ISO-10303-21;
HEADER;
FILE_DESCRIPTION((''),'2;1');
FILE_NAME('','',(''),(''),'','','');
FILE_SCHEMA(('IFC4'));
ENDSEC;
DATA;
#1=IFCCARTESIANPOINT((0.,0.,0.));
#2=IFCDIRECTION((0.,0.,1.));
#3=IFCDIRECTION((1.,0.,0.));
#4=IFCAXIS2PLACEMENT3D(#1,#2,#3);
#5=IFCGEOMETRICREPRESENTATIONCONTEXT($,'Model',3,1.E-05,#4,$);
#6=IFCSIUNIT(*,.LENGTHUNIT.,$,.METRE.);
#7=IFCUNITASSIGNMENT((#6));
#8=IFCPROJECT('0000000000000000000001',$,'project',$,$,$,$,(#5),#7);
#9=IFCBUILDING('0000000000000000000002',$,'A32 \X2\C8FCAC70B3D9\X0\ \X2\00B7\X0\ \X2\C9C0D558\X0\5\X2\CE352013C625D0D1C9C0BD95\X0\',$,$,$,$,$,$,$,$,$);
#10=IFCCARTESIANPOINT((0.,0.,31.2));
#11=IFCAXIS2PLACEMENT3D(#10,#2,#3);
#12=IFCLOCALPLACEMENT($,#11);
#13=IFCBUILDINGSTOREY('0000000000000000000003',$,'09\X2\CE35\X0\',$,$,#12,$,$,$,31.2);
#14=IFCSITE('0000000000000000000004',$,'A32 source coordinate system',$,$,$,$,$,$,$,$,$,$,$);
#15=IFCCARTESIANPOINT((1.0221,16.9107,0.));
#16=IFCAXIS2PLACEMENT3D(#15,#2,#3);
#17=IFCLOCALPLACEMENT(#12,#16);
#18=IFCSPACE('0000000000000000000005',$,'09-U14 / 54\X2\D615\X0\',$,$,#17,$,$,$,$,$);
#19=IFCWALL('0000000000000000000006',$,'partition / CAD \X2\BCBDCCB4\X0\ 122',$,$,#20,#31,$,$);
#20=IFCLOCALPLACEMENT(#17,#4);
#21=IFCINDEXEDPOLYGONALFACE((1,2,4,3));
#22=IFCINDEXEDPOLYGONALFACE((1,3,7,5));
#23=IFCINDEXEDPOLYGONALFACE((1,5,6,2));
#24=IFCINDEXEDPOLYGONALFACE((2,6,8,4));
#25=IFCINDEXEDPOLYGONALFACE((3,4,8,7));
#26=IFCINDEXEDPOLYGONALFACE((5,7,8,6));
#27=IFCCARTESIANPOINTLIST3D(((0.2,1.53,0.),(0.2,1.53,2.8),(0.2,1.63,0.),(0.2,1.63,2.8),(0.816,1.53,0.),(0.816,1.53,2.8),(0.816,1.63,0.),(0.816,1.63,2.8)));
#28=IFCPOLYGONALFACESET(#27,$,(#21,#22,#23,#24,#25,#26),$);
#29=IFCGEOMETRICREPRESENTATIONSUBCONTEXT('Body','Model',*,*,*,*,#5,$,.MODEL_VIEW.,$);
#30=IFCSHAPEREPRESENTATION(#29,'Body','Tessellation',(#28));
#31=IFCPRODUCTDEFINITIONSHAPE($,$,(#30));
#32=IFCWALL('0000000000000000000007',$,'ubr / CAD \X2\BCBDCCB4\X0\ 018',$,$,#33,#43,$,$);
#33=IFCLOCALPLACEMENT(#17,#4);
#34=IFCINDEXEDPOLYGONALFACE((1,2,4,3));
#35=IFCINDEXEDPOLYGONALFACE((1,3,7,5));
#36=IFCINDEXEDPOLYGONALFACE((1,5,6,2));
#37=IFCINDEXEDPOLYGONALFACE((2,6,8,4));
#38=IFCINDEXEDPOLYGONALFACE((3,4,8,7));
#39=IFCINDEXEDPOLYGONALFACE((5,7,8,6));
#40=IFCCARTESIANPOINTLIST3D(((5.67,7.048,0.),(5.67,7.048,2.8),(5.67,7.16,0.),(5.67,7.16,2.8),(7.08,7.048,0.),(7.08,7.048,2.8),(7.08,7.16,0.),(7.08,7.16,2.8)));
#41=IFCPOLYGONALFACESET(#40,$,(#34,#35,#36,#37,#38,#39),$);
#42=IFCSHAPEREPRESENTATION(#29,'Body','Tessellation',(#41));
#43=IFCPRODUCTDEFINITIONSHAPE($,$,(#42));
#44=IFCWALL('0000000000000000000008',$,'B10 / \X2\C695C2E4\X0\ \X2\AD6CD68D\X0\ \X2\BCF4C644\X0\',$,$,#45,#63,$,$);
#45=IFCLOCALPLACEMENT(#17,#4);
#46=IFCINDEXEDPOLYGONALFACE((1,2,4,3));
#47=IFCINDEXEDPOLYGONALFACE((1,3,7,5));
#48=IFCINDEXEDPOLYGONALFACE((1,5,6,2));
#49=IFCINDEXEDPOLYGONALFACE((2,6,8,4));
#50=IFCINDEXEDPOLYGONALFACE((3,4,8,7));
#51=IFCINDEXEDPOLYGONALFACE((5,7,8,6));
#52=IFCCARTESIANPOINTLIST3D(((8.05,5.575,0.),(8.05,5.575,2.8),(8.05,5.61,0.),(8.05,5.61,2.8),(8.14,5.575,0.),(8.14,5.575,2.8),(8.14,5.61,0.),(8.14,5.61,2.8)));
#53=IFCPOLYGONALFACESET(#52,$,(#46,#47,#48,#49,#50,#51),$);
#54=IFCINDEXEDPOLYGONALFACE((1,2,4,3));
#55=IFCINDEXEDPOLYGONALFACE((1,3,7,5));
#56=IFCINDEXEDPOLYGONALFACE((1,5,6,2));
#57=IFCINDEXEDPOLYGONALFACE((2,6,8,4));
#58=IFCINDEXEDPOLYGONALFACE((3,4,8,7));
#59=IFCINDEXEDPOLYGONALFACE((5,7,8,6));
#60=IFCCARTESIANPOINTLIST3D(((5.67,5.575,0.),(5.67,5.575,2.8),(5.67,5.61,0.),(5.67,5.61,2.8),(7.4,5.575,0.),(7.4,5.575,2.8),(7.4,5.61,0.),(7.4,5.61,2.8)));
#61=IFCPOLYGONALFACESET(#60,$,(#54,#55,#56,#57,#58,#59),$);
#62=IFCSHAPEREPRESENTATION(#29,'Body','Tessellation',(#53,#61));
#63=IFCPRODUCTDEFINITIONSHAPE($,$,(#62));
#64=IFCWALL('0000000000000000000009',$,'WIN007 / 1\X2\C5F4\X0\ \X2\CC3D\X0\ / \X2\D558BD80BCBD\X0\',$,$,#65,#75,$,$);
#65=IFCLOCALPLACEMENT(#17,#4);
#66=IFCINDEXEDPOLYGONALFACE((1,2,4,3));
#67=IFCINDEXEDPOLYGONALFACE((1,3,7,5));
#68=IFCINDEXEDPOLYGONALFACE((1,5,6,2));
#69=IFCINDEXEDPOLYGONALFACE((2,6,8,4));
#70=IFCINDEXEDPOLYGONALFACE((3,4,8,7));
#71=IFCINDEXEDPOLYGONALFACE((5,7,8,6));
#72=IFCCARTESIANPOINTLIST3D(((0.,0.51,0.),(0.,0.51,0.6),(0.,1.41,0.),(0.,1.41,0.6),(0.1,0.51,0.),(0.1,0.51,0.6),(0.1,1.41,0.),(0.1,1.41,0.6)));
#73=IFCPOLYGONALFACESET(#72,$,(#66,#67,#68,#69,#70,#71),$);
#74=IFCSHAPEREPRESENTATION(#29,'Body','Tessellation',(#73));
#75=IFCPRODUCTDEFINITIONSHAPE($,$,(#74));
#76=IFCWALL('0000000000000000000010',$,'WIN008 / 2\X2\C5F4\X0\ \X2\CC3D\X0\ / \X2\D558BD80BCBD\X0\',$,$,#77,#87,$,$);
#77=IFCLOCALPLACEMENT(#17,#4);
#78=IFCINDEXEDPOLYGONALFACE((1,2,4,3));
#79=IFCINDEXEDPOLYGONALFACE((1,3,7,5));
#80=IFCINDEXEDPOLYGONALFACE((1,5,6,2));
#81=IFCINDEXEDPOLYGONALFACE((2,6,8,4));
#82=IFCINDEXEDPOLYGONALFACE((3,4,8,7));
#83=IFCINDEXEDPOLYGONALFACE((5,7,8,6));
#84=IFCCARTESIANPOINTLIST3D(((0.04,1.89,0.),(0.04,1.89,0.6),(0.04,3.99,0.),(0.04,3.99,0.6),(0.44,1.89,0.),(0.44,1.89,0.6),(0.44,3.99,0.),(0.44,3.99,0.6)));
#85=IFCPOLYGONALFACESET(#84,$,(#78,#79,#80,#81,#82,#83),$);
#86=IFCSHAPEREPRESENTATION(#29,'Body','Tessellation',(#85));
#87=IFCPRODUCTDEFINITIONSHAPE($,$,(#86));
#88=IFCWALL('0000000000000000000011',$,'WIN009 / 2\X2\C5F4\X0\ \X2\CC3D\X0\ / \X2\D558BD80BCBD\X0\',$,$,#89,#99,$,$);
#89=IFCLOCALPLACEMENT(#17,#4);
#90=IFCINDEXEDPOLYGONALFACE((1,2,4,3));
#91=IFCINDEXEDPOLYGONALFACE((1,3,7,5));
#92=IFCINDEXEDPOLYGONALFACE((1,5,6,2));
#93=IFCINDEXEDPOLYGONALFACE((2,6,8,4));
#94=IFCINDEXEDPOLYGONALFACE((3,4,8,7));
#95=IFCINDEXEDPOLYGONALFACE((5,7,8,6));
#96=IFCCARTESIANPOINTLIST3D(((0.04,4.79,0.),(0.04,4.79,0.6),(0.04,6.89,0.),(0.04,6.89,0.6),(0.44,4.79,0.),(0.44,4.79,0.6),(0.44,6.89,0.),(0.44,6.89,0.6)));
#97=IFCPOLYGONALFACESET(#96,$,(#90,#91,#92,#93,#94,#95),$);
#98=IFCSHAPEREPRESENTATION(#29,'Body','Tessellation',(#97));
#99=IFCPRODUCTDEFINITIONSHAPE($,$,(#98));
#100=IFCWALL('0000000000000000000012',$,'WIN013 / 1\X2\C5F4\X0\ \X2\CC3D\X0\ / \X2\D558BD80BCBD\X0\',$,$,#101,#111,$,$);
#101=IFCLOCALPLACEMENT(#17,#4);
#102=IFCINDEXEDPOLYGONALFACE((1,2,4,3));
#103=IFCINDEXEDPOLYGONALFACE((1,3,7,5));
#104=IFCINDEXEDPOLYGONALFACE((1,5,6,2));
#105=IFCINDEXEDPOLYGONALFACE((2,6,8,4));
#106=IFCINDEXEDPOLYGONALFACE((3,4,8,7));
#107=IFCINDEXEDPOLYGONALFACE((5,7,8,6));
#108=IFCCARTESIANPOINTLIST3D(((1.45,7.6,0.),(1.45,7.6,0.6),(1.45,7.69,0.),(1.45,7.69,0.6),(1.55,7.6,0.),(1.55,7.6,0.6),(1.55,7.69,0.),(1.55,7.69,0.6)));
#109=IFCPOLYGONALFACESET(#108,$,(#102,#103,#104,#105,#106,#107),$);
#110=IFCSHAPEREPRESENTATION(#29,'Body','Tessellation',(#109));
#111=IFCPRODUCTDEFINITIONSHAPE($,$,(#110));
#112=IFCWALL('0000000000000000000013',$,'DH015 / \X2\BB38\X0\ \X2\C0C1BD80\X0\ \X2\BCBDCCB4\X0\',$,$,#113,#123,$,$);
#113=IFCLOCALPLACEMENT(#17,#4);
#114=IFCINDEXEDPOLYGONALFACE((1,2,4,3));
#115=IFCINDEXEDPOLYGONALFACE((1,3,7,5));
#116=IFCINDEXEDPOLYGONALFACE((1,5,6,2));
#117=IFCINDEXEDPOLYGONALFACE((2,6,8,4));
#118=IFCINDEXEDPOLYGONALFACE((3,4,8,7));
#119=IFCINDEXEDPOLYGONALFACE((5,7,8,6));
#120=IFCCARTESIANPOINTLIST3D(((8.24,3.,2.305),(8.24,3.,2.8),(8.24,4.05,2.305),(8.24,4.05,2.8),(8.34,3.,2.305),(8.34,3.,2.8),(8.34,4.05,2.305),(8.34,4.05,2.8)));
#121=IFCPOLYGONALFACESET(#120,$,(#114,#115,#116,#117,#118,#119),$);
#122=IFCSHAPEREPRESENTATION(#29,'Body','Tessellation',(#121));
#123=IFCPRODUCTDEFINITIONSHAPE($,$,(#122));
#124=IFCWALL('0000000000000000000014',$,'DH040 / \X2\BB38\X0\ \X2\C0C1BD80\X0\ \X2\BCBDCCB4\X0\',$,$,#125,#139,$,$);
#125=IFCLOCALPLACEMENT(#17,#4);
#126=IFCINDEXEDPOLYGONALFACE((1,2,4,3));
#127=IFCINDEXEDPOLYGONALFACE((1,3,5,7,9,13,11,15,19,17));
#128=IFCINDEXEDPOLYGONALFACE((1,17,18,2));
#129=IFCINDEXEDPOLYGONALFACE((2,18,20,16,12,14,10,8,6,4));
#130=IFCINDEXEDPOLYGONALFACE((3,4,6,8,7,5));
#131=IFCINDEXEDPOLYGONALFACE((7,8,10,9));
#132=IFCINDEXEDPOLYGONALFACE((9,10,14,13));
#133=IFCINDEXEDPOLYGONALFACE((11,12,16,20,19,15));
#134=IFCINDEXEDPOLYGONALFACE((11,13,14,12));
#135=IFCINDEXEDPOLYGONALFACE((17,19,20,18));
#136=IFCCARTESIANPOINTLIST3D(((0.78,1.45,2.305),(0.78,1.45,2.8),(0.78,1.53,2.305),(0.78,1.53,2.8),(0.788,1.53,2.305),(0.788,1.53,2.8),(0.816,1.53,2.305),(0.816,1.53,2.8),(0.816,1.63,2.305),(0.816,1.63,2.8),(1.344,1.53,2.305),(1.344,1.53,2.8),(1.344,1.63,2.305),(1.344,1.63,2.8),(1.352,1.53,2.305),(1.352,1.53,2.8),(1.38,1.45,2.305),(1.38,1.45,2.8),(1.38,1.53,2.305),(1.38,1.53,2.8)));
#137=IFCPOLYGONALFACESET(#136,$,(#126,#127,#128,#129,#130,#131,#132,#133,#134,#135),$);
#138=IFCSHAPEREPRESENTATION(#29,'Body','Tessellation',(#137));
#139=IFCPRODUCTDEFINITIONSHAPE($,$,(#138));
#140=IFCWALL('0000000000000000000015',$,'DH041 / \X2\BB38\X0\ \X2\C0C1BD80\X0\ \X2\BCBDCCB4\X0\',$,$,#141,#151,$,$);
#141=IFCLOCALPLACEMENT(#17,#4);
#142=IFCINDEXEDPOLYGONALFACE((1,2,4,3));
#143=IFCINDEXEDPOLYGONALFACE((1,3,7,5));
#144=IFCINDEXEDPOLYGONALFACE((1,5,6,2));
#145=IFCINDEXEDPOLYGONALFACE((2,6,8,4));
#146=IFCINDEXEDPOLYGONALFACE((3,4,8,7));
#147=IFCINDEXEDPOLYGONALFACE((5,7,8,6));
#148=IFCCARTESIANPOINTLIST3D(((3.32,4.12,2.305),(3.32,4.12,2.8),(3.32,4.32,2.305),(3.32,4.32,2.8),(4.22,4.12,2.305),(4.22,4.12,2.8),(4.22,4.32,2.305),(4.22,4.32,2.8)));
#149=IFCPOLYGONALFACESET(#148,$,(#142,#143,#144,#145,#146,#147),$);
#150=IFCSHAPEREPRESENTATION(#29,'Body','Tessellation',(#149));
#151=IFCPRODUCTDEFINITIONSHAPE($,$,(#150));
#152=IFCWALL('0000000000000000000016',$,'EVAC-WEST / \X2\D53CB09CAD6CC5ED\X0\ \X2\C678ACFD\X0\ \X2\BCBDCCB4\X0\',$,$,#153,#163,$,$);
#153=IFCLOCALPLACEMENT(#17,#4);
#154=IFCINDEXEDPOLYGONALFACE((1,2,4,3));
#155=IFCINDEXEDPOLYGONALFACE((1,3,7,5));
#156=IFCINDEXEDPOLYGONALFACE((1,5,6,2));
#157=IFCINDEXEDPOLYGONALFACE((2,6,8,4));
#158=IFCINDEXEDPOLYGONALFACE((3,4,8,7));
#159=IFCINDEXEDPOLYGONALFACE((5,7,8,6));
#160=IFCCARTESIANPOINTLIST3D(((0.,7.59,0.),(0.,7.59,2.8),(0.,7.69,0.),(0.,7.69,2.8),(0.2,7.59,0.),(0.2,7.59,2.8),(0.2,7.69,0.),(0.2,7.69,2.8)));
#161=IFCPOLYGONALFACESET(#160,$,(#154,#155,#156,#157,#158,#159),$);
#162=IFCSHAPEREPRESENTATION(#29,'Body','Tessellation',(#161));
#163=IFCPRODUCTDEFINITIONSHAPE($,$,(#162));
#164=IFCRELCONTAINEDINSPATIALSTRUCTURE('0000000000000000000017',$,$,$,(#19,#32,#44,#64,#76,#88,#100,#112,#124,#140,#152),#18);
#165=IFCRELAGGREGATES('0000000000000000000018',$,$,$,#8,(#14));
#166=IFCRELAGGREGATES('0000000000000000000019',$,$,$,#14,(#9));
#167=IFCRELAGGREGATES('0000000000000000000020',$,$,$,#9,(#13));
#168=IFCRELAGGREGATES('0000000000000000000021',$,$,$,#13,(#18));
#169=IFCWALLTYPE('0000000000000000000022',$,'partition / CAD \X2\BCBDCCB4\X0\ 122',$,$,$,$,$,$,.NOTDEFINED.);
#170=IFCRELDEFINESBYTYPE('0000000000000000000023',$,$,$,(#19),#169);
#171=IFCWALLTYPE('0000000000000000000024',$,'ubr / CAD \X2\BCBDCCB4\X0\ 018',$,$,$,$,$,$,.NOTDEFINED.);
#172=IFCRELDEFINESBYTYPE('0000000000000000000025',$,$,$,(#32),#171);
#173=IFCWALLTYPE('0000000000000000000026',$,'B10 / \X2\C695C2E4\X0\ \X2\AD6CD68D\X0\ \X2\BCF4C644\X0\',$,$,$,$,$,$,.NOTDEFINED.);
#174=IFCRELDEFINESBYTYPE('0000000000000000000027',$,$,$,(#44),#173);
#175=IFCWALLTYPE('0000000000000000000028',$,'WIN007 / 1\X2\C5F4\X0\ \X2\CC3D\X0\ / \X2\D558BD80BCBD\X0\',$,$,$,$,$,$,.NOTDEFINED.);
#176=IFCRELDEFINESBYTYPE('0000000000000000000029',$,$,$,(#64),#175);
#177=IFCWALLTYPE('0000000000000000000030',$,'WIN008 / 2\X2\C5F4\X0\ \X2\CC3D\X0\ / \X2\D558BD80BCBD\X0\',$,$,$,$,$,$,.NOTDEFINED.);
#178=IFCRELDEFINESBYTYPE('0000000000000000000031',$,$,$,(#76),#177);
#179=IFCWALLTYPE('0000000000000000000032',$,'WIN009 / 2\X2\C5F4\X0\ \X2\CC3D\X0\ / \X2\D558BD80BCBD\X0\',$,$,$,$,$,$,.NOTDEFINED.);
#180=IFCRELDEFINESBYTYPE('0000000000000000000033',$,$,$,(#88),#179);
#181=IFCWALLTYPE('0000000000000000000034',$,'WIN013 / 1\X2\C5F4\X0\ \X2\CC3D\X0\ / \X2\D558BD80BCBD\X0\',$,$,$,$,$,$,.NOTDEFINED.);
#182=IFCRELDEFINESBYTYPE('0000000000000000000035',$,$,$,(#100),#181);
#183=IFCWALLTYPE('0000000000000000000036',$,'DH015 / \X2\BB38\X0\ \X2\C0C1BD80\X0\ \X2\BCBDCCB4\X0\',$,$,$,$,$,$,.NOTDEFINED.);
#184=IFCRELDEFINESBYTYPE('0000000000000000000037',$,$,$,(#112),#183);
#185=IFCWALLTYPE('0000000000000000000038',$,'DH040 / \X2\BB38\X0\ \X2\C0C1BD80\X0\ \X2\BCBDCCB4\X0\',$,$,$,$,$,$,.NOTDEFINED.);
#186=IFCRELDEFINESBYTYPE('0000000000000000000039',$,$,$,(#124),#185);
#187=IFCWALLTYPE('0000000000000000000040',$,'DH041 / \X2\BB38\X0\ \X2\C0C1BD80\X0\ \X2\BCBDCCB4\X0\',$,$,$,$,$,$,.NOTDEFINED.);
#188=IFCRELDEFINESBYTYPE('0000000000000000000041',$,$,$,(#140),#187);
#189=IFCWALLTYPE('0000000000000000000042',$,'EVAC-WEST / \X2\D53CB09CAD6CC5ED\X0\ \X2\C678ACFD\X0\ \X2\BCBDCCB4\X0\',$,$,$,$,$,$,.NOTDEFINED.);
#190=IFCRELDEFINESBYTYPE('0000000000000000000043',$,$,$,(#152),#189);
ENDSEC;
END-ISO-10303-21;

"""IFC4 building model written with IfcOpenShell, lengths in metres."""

from ifc_helpers import new_model, si_unit, frame, origin, origin_with_axes, place, context, subcontext, project, spatial, polyline, outline, extrude, source, transform, mapped, type_object, type_shapes, element, save


model = new_model("IFC4")

# Units and contexts
model_context = context("Model", 3, precision=1e-05, world=origin_with_axes())
body_context = subcontext(model_context, "Body", "Model", "MODEL_VIEW")
ifc_project = project(units=[si_unit("LENGTHUNIT", "METRE")], contexts=[model_context])

# Site, building, storey, space
site = spatial("IfcSite", under=ifc_project, Name="A32 source coordinate system")
building = spatial("IfcBuilding", under=site, Name="A32 주거동 · 지하5층–옥탑지붕")
storey_placement = place(None, frame((0.0, 0.0, 31.2), z_axis=(0.0, 0.0, 1.0), x_axis=(1.0, 0.0, 0.0)))
storey = spatial("IfcBuildingStorey", under=building, at=storey_placement, Name="09층", Elevation=31.2)
space_placement = place(storey_placement, frame((1.0221, 16.9107, 0.0), z_axis=(0.0, 0.0, 1.0), x_axis=(1.0, 0.0, 0.0)))
space = spatial("IfcSpace", under=storey, at=space_placement, Name="09-U14 / 54형")

# Walls
wall_type_1 = type_object("IfcWallType", Name="partition / CAD 벽체 122", PredefinedType="NOTDEFINED")
shared_shape_1 = source(origin(), body_context, "Body", "SweptSolid", [
    extrude(outline(polyline([(0.816, 1.63), (0.816, 1.53), (0.2, 1.53), (0.2, 1.63), (0.816, 1.63)])), origin(), (0.0, 0.0, 1.0), 2.8),
])
type_shapes(wall_type_1, [shared_shape_1])
wall_1_placement = place(space_placement, origin_with_axes())
element("IfcWall", 1, at=wall_1_placement, inside=space, type_object=wall_type_1, Name="partition / CAD 벽체 122", context=body_context, shape_type="MappedRepresentation", body=[
    mapped(shared_shape_1, transform((0.0, 0.0, 0.0), scale=1.0)),
])
wall_type_2 = type_object("IfcWallType", Name="ubr / CAD 벽체 018", PredefinedType="NOTDEFINED")
shared_shape_2 = source(origin(), body_context, "Body", "SweptSolid", [
    extrude(outline(polyline([(5.67, 7.16), (7.08, 7.16), (7.08, 7.048), (5.67, 7.048), (5.67, 7.16)])), origin(), (0.0, 0.0, 1.0), 2.8),
])
type_shapes(wall_type_2, [shared_shape_2])
wall_2_placement = place(space_placement, origin_with_axes())
element("IfcWall", 2, at=wall_2_placement, inside=space, type_object=wall_type_2, Name="ubr / CAD 벽체 018", context=body_context, shape_type="MappedRepresentation", body=[
    mapped(shared_shape_2, transform((0.0, 0.0, 0.0), scale=1.0)),
])
wall_type_3 = type_object("IfcWallType", Name="B10 / 욕실 구획 보완", PredefinedType="NOTDEFINED")
shared_shape_3 = source(origin(), body_context, "Body", "SweptSolid", [
    extrude(outline(polyline([(8.14, 5.575), (8.05, 5.575), (8.05, 5.61), (8.14, 5.61), (8.14, 5.575)])), origin(), (0.0, 0.0, 1.0), 2.8),
    extrude(outline(polyline([(7.4, 5.575), (5.67, 5.575), (5.67, 5.61), (7.4, 5.61), (7.4, 5.575)])), origin(), (0.0, 0.0, 1.0), 2.8),
])
type_shapes(wall_type_3, [shared_shape_3])
wall_3_placement = place(space_placement, origin_with_axes())
element("IfcWall", 3, at=wall_3_placement, inside=space, type_object=wall_type_3, Name="B10 / 욕실 구획 보완", context=body_context, shape_type="MappedRepresentation", body=[
    mapped(shared_shape_3, transform((0.0, 0.0, 0.0), scale=1.0)),
])
wall_type_4 = type_object("IfcWallType", Name="WIN007 / 1열 창 / 하부벽", PredefinedType="NOTDEFINED")
shared_shape_4 = source(origin(), body_context, "Body", "SweptSolid", [
    extrude(outline(polyline([(0.1, 1.41), (0.1, 0.51), (0.0, 0.51), (0.0, 1.41), (0.1, 1.41)])), origin(), (0.0, 0.0, 1.0), 0.6),
])
type_shapes(wall_type_4, [shared_shape_4])
wall_4_placement = place(space_placement, origin_with_axes())
element("IfcWall", 4, at=wall_4_placement, inside=space, type_object=wall_type_4, Name="WIN007 / 1열 창 / 하부벽", context=body_context, shape_type="MappedRepresentation", body=[
    mapped(shared_shape_4, transform((0.0, 0.0, 0.0), scale=1.0)),
])
wall_type_5 = type_object("IfcWallType", Name="WIN008 / 2열 창 / 하부벽", PredefinedType="NOTDEFINED")
shared_shape_5 = source(origin(), body_context, "Body", "SweptSolid", [
    extrude(outline(polyline([(0.44, 3.99), (0.44, 1.89), (0.04, 1.89), (0.04, 3.99), (0.44, 3.99)])), origin(), (0.0, 0.0, 1.0), 0.6),
])
type_shapes(wall_type_5, [shared_shape_5])
wall_5_placement = place(space_placement, origin_with_axes())
element("IfcWall", 5, at=wall_5_placement, inside=space, type_object=wall_type_5, Name="WIN008 / 2열 창 / 하부벽", context=body_context, shape_type="MappedRepresentation", body=[
    mapped(shared_shape_5, transform((0.0, 0.0, 0.0), scale=1.0)),
])
wall_type_6 = type_object("IfcWallType", Name="WIN009 / 2열 창 / 하부벽", PredefinedType="NOTDEFINED")
shared_shape_6 = source(origin(), body_context, "Body", "SweptSolid", [
    extrude(outline(polyline([(0.44, 6.89), (0.44, 4.79), (0.04, 4.79), (0.04, 6.89), (0.44, 6.89)])), origin(), (0.0, 0.0, 1.0), 0.6),
])
type_shapes(wall_type_6, [shared_shape_6])
wall_6_placement = place(space_placement, origin_with_axes())
element("IfcWall", 6, at=wall_6_placement, inside=space, type_object=wall_type_6, Name="WIN009 / 2열 창 / 하부벽", context=body_context, shape_type="MappedRepresentation", body=[
    mapped(shared_shape_6, transform((0.0, 0.0, 0.0), scale=1.0)),
])
wall_type_7 = type_object("IfcWallType", Name="WIN013 / 1열 창 / 하부벽", PredefinedType="NOTDEFINED")
shared_shape_7 = source(origin(), body_context, "Body", "SweptSolid", [
    extrude(outline(polyline([(1.55, 7.6), (1.45, 7.6), (1.45, 7.69), (1.55, 7.69), (1.55, 7.6)])), origin(), (0.0, 0.0, 1.0), 0.6),
])
type_shapes(wall_type_7, [shared_shape_7])
wall_7_placement = place(space_placement, origin_with_axes())
element("IfcWall", 7, at=wall_7_placement, inside=space, type_object=wall_type_7, Name="WIN013 / 1열 창 / 하부벽", context=body_context, shape_type="MappedRepresentation", body=[
    mapped(shared_shape_7, transform((0.0, 0.0, 0.0), scale=1.0)),
])
wall_type_8 = type_object("IfcWallType", Name="DH015 / 문 상부 벽체", PredefinedType="NOTDEFINED")
shared_shape_8 = source(origin(), body_context, "Body", "SweptSolid", [
    extrude(outline(polyline([(8.34, 3.0), (8.24, 3.0), (8.24, 4.05), (8.34, 4.05), (8.34, 3.0)])), frame((0.0, 0.0, 2.305)), (0.0, 0.0, 1.0), 0.495),
])
type_shapes(wall_type_8, [shared_shape_8])
wall_8_placement = place(space_placement, origin_with_axes())
element("IfcWall", 8, at=wall_8_placement, inside=space, type_object=wall_type_8, Name="DH015 / 문 상부 벽체", context=body_context, shape_type="MappedRepresentation", body=[
    mapped(shared_shape_8, transform((0.0, 0.0, 0.0), scale=1.0)),
])
wall_type_9 = type_object("IfcWallType", Name="DH040 / 문 상부 벽체", PredefinedType="NOTDEFINED")
shared_shape_9 = source(origin(), body_context, "Body", "SweptSolid", [
    extrude(outline(polyline([(0.816, 1.63), (1.344, 1.63), (1.344, 1.53), (1.352, 1.53), (1.38, 1.53), (1.38, 1.45), (0.78, 1.45), (0.78, 1.53), (0.788, 1.53), (0.816, 1.53), (0.816, 1.63)])), frame((0.0, 0.0, 2.305)), (0.0, 0.0, 1.0), 0.495),
])
type_shapes(wall_type_9, [shared_shape_9])
wall_9_placement = place(space_placement, origin_with_axes())
element("IfcWall", 9, at=wall_9_placement, inside=space, type_object=wall_type_9, Name="DH040 / 문 상부 벽체", context=body_context, shape_type="MappedRepresentation", body=[
    mapped(shared_shape_9, transform((0.0, 0.0, 0.0), scale=1.0)),
])
wall_type_10 = type_object("IfcWallType", Name="DH041 / 문 상부 벽체", PredefinedType="NOTDEFINED")
shared_shape_10 = source(origin(), body_context, "Body", "SweptSolid", [
    extrude(outline(polyline([(4.22, 4.12), (3.32, 4.12), (3.32, 4.32), (4.22, 4.32), (4.22, 4.12)])), frame((0.0, 0.0, 2.305)), (0.0, 0.0, 1.0), 0.495),
])
type_shapes(wall_type_10, [shared_shape_10])
wall_10_placement = place(space_placement, origin_with_axes())
element("IfcWall", 10, at=wall_10_placement, inside=space, type_object=wall_type_10, Name="DH041 / 문 상부 벽체", context=body_context, shape_type="MappedRepresentation", body=[
    mapped(shared_shape_10, transform((0.0, 0.0, 0.0), scale=1.0)),
])
wall_type_11 = type_object("IfcWallType", Name="EVAC-WEST / 피난구역 외곽 벽체", PredefinedType="NOTDEFINED")
shared_shape_11 = source(origin(), body_context, "Body", "SweptSolid", [
    extrude(outline(polyline([(0.2, 7.59), (0.0, 7.59), (0.0, 7.69), (0.2, 7.69), (0.2, 7.59)])), origin(), (0.0, 0.0, 1.0), 2.8),
])
type_shapes(wall_type_11, [shared_shape_11])
wall_11_placement = place(space_placement, origin_with_axes())
element("IfcWall", 11, at=wall_11_placement, inside=space, type_object=wall_type_11, Name="EVAC-WEST / 피난구역 외곽 벽체", context=body_context, shape_type="MappedRepresentation", body=[
    mapped(shared_shape_11, transform((0.0, 0.0, 0.0), scale=1.0)),
])

save(model, "model.ifc")
